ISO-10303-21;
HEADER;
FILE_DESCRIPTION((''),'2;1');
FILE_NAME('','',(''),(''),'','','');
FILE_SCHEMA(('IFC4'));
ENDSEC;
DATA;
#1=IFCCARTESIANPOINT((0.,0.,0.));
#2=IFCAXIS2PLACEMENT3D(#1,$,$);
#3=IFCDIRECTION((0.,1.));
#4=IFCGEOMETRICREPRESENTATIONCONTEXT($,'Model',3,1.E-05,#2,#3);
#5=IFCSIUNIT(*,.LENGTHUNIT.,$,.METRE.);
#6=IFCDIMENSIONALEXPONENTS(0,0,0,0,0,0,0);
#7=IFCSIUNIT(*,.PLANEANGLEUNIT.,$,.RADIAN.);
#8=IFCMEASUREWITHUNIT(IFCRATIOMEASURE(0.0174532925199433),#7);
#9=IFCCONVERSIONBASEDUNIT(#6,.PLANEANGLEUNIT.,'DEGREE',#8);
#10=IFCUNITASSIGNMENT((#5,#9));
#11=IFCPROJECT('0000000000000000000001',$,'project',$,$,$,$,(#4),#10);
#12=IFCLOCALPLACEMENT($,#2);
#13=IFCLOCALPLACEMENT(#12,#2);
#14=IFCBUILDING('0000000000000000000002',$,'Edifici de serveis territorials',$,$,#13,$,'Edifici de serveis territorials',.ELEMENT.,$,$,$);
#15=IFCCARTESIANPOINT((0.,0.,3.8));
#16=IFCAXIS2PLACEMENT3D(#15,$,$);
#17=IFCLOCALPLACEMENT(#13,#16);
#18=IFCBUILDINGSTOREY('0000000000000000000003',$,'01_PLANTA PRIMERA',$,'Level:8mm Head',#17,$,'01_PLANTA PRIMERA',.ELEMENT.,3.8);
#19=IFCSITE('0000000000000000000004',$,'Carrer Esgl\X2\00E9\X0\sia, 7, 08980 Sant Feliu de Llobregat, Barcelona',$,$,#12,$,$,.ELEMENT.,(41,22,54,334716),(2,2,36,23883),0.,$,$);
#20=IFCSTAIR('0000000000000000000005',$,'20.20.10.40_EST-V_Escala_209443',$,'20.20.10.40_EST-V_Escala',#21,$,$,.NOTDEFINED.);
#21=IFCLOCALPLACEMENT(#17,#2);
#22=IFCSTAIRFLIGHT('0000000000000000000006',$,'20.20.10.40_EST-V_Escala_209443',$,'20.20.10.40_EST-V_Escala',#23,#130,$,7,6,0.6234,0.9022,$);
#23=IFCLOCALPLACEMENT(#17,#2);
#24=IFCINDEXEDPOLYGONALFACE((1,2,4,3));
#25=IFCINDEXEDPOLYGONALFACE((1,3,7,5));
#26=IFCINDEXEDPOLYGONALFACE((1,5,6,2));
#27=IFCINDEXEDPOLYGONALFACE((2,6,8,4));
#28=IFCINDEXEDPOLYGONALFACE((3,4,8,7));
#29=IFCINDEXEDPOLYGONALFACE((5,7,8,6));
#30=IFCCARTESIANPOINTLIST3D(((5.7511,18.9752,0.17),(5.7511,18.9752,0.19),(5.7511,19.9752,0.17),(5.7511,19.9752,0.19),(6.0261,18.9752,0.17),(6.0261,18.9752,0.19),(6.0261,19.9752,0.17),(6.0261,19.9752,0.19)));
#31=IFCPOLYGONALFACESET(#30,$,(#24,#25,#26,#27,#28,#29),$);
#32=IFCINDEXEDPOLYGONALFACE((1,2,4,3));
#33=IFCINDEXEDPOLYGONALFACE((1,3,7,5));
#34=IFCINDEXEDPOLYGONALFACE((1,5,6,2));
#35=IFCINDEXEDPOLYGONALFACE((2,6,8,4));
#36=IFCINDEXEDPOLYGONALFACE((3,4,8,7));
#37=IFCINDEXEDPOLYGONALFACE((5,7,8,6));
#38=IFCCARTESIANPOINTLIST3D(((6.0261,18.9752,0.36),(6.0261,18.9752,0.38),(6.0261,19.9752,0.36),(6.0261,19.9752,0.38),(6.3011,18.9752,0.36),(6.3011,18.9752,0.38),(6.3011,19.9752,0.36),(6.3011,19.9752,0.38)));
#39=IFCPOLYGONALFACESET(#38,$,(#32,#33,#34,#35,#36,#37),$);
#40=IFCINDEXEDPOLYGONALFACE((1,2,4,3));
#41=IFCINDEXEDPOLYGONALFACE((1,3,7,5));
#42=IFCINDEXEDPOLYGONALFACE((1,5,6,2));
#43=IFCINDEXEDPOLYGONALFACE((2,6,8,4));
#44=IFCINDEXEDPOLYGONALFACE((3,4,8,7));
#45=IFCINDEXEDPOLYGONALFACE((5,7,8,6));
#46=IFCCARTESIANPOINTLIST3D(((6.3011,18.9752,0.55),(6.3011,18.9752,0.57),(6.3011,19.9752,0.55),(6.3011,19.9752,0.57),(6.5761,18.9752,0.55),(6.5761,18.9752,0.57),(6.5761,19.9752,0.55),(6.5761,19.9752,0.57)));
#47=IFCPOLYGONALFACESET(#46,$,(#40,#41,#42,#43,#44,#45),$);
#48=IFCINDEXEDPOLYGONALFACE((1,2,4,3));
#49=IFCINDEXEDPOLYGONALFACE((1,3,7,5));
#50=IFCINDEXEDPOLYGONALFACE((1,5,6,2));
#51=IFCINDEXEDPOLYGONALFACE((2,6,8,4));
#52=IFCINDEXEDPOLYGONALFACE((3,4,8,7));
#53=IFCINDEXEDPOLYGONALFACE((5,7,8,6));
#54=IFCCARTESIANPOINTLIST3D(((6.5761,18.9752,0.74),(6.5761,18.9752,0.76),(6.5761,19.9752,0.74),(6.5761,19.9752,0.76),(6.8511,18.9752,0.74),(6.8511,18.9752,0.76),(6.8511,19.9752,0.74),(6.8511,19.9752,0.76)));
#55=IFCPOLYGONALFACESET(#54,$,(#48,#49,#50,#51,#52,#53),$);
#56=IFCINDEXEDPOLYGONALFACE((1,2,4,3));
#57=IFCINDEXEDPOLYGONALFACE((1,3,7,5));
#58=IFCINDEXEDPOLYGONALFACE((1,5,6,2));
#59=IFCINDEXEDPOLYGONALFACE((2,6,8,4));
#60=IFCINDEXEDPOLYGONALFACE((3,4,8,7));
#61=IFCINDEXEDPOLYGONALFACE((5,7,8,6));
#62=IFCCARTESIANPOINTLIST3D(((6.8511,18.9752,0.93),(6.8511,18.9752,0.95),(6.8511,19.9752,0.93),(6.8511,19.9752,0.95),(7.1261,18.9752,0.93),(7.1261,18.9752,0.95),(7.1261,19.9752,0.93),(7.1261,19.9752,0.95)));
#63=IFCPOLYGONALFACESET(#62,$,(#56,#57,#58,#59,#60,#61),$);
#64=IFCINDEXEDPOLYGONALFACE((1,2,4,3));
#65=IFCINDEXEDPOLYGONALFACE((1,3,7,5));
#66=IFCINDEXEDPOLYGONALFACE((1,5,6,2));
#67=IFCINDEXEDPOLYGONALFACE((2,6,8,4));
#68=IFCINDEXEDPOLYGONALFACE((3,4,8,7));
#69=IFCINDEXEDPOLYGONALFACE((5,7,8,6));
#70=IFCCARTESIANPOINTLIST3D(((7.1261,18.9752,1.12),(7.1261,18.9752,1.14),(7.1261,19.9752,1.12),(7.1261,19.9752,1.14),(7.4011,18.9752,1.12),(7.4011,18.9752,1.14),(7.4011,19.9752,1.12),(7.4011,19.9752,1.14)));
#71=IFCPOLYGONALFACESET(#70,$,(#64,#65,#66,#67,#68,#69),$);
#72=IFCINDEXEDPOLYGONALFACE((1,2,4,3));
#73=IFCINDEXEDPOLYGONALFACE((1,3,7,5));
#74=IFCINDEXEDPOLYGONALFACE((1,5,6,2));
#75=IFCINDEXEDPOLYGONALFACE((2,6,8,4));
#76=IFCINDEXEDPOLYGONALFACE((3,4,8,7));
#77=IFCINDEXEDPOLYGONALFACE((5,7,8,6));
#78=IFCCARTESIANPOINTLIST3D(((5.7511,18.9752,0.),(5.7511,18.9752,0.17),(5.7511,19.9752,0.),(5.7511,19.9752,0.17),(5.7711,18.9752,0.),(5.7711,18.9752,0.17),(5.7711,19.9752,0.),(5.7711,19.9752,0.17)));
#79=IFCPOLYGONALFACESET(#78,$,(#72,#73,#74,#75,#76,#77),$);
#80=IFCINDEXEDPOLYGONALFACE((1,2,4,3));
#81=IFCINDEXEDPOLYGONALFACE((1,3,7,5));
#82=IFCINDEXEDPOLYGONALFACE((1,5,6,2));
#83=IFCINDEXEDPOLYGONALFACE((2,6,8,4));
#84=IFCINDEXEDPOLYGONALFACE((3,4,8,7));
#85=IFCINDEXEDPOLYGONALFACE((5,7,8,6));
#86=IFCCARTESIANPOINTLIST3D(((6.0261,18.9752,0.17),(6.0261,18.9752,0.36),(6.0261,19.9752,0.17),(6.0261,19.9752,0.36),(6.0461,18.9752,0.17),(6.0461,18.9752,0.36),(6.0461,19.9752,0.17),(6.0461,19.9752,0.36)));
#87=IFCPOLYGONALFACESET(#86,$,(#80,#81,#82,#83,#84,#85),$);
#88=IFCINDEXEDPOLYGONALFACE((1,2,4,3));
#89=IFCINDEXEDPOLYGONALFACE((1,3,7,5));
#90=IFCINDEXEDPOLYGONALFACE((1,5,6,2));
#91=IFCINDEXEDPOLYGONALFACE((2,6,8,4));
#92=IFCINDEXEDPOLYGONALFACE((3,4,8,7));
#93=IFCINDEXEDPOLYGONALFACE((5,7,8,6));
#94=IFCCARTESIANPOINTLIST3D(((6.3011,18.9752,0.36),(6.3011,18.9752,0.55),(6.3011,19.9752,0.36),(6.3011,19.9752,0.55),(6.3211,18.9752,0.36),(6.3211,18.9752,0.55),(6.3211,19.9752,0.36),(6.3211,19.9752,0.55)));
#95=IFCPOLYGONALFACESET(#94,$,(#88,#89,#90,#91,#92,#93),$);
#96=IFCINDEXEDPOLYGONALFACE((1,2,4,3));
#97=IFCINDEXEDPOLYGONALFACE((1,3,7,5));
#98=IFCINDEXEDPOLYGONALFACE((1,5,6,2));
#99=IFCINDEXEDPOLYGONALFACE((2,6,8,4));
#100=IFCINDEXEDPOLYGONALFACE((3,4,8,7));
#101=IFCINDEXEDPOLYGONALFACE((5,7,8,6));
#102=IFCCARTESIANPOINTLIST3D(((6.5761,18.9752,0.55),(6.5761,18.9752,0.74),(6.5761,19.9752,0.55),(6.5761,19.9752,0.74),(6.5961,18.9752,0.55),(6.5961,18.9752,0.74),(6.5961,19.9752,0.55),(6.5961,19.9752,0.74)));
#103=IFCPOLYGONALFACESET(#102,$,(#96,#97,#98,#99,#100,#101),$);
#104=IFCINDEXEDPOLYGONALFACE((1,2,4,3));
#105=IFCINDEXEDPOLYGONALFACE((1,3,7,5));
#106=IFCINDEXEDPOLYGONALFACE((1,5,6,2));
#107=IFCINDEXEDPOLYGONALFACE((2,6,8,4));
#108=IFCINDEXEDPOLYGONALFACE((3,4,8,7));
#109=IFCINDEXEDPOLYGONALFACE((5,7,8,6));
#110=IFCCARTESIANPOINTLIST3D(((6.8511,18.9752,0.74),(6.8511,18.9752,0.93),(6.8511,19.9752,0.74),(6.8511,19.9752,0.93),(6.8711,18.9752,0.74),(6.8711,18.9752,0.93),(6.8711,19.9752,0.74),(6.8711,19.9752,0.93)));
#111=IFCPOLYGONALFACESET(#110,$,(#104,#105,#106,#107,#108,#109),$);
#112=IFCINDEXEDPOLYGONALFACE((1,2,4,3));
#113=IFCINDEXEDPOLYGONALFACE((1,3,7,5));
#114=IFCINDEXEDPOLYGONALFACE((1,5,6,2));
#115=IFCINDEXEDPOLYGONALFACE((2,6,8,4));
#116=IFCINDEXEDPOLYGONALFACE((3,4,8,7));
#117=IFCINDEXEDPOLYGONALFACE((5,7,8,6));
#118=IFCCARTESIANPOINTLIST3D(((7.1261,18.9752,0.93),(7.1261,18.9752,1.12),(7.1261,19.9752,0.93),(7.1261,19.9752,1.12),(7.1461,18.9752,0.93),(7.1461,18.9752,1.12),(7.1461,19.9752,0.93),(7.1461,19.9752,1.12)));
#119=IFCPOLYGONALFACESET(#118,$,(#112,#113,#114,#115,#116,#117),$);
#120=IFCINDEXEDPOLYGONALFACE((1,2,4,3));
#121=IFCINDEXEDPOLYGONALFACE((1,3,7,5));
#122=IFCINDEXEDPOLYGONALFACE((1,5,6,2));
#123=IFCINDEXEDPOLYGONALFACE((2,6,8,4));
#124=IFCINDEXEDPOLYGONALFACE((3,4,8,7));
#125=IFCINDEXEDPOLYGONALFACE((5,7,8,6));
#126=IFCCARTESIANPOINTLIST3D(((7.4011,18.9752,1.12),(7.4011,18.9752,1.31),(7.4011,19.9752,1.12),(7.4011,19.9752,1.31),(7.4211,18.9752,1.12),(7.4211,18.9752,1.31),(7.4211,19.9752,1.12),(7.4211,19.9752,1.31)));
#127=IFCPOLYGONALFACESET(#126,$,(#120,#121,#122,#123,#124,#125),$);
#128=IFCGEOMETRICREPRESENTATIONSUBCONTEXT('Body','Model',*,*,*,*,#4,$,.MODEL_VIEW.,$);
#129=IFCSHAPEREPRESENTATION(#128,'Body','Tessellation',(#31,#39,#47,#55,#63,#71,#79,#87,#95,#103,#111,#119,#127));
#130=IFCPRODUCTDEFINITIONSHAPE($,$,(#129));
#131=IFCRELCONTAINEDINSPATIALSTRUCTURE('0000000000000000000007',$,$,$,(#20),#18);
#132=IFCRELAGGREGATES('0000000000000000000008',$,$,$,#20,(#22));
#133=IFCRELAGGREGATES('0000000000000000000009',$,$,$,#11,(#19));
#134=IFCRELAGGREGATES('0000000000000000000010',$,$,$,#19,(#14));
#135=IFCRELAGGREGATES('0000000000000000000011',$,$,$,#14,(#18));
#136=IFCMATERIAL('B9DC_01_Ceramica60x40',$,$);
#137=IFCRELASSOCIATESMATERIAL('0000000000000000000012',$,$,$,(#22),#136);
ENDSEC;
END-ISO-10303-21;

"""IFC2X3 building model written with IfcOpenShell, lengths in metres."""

from ifc_helpers import new_model, entity, si_unit, converted_unit, direction, frame, frame_2d, origin, origin_2d_with_axis, place, context, subcontext, project, spatial, polyline, rectangle, outline, extrude, material, element, aggregate, save


model = new_model("IFC2X3")

# Units and contexts
model_context = context("Model", 3, precision=1e-05, world=origin(), true_north=direction((0.0, 1.0)))
body_context = subcontext(model_context, "Body", "Model", "MODEL_VIEW")
ifc_project = project(units=[si_unit("LENGTHUNIT", "METRE"), converted_unit("PLANEANGLEUNIT", "DEGREE", entity("IfcRatioMeasure", 0.0174532925199433), si_unit("PLANEANGLEUNIT", "RADIAN"), dimensions=[0, 0, 0, 0, 0, 0, 0])], contexts=[model_context])

# Site, building, storey
site_placement = place(None, origin())
site = spatial("IfcSite", under=ifc_project, at=site_placement, Name="Carrer Església, 7, 08980 Sant Feliu de Llobregat, Barcelona", CompositionType="ELEMENT", RefLatitude=(41, 22, 54, 334716), RefLongitude=(2, 2, 36, 23883), RefElevation=0.0)
building_placement = place(site_placement, origin())
building = spatial("IfcBuilding", under=site, at=building_placement, Name="Edifici de serveis territorials", LongName="Edifici de serveis territorials", CompositionType="ELEMENT")
storey_placement = place(building_placement, frame((0.0, 0.0, 3.8)))
storey = spatial("IfcBuildingStorey", under=building, at=storey_placement, Name="01_PLANTA PRIMERA", ObjectType="Level:8mm Head", LongName="01_PLANTA PRIMERA", CompositionType="ELEMENT", Elevation=3.8)

# Shared definitions
ifc_material_1 = material(Name="B9DC_01_Ceramica60x40")

# Stair
stair_placement = place(storey_placement, origin())
stair = element("IfcStair", 1, at=stair_placement, inside=storey, Name="20.20.10.40_EST-V_Escala_209443", ObjectType="20.20.10.40_EST-V_Escala", ShapeType="NOTDEFINED")

# Stair flight
stair_flight_1_placement = place(stair_placement, origin())
stair_flight_1 = element("IfcStairFlight", 2, at=stair_flight_1_placement, material=ifc_material_1, Name="20.20.10.40_EST-V_Escala_209443", ObjectType="20.20.10.40_EST-V_Escala", NumberOfRiser=7, NumberOfTreads=6, RiserHeight=0.6234, TreadLength=0.9022, context=body_context, shape_type="SweptSolid", body=[
    extrude(rectangle(XDim=0.275, YDim=1.0, at=origin_2d_with_axis()), frame((5.8886, 19.4752, 0.17), z_axis=(0.0, 0.0, 1.0), x_axis=(-1.0, 0.0, 0.0)), (0.0, 0.0, 1.0), 0.02),
    extrude(rectangle(XDim=0.275, YDim=1.0, at=frame_2d((0.0, 0.0), x_axis=(1.0, 0.0))), frame((6.1636, 19.4752, 0.36), z_axis=(0.0, 0.0, 1.0), x_axis=(-1.0, 0.0, 0.0)), (0.0, 0.0, 1.0), 0.02),
    extrude(rectangle(XDim=0.275, YDim=1.0, at=frame_2d((0.0, 0.0), x_axis=(1.0, 0.0))), frame((6.4386, 19.4752, 0.55), z_axis=(0.0, 0.0, 1.0), x_axis=(-1.0, 0.0, 0.0)), (0.0, 0.0, 1.0), 0.02),
    extrude(rectangle(XDim=0.275, YDim=1.0, at=frame_2d((0.0, 0.0), x_axis=(1.0, 0.0))), frame((6.7136, 19.4752, 0.74), z_axis=(0.0, 0.0, 1.0), x_axis=(-1.0, 0.0, 0.0)), (0.0, 0.0, 1.0), 0.02),
    extrude(rectangle(XDim=0.275, YDim=1.0, at=frame_2d((0.0, 0.0), x_axis=(1.0, 0.0))), frame((6.9886, 19.4752, 0.93), z_axis=(0.0, 0.0, 1.0), x_axis=(-1.0, 0.0, 0.0)), (0.0, 0.0, 1.0), 0.02),
    extrude(rectangle(XDim=0.275, YDim=1.0, at=origin_2d_with_axis()), frame((7.2636, 19.4752, 1.12), z_axis=(0.0, 0.0, 1.0), x_axis=(-1.0, 0.0, 0.0)), (0.0, 0.0, 1.0), 0.02),
    extrude(rectangle(XDim=1.0, YDim=0.02, at=origin_2d_with_axis()), frame((5.7611, 19.4752, 0.0), z_axis=(0.0, 0.0, 1.0), x_axis=(0.0, 1.0, 0.0)), (0.0, 0.0, 1.0), 0.17),
    extrude(rectangle(XDim=1.0, YDim=0.02, at=origin_2d_with_axis()), frame((6.0361, 19.4752, 0.17), z_axis=(0.0, 0.0, 1.0), x_axis=(0.0, 1.0, 0.0)), (0.0, 0.0, 1.0), 0.19),
    extrude(rectangle(XDim=1.0, YDim=0.02, at=origin_2d_with_axis()), frame((6.3111, 19.4752, 0.36), z_axis=(0.0, 0.0, 1.0), x_axis=(0.0, 1.0, 0.0)), (0.0, 0.0, 1.0), 0.19),
    extrude(rectangle(XDim=1.0, YDim=0.02, at=frame_2d((0.0, 0.0), x_axis=(1.0, 0.0))), frame((6.5861, 19.4752, 0.55), z_axis=(0.0, 0.0, 1.0), x_axis=(0.0, 1.0, 0.0)), (0.0, 0.0, 1.0), 0.19),
    extrude(rectangle(XDim=1.0, YDim=0.02, at=origin_2d_with_axis()), frame((6.8611, 19.4752, 0.74), z_axis=(0.0, 0.0, 1.0), x_axis=(0.0, 1.0, 0.0)), (0.0, 0.0, 1.0), 0.19),
    extrude(rectangle(XDim=1.0, YDim=0.02, at=origin_2d_with_axis()), frame((7.1361, 19.4752, 0.93), z_axis=(0.0, 0.0, 1.0), x_axis=(0.0, 1.0, 0.0)), (0.0, 0.0, 1.0), 0.19),
    extrude(outline(polyline([(-0.5, -0.01), (0.5, -0.01), (0.5, 0.01), (-0.5, 0.01), (-0.5, -0.01)])), frame((7.4111, 19.4752, 1.12), z_axis=(0.0, 0.0, 1.0), x_axis=(0.0, 1.0, 0.0)), (0.0, 0.0, 1.0), 0.19),
])
aggregate(stair, [stair_flight_1])

save(model, "model.ifc")
